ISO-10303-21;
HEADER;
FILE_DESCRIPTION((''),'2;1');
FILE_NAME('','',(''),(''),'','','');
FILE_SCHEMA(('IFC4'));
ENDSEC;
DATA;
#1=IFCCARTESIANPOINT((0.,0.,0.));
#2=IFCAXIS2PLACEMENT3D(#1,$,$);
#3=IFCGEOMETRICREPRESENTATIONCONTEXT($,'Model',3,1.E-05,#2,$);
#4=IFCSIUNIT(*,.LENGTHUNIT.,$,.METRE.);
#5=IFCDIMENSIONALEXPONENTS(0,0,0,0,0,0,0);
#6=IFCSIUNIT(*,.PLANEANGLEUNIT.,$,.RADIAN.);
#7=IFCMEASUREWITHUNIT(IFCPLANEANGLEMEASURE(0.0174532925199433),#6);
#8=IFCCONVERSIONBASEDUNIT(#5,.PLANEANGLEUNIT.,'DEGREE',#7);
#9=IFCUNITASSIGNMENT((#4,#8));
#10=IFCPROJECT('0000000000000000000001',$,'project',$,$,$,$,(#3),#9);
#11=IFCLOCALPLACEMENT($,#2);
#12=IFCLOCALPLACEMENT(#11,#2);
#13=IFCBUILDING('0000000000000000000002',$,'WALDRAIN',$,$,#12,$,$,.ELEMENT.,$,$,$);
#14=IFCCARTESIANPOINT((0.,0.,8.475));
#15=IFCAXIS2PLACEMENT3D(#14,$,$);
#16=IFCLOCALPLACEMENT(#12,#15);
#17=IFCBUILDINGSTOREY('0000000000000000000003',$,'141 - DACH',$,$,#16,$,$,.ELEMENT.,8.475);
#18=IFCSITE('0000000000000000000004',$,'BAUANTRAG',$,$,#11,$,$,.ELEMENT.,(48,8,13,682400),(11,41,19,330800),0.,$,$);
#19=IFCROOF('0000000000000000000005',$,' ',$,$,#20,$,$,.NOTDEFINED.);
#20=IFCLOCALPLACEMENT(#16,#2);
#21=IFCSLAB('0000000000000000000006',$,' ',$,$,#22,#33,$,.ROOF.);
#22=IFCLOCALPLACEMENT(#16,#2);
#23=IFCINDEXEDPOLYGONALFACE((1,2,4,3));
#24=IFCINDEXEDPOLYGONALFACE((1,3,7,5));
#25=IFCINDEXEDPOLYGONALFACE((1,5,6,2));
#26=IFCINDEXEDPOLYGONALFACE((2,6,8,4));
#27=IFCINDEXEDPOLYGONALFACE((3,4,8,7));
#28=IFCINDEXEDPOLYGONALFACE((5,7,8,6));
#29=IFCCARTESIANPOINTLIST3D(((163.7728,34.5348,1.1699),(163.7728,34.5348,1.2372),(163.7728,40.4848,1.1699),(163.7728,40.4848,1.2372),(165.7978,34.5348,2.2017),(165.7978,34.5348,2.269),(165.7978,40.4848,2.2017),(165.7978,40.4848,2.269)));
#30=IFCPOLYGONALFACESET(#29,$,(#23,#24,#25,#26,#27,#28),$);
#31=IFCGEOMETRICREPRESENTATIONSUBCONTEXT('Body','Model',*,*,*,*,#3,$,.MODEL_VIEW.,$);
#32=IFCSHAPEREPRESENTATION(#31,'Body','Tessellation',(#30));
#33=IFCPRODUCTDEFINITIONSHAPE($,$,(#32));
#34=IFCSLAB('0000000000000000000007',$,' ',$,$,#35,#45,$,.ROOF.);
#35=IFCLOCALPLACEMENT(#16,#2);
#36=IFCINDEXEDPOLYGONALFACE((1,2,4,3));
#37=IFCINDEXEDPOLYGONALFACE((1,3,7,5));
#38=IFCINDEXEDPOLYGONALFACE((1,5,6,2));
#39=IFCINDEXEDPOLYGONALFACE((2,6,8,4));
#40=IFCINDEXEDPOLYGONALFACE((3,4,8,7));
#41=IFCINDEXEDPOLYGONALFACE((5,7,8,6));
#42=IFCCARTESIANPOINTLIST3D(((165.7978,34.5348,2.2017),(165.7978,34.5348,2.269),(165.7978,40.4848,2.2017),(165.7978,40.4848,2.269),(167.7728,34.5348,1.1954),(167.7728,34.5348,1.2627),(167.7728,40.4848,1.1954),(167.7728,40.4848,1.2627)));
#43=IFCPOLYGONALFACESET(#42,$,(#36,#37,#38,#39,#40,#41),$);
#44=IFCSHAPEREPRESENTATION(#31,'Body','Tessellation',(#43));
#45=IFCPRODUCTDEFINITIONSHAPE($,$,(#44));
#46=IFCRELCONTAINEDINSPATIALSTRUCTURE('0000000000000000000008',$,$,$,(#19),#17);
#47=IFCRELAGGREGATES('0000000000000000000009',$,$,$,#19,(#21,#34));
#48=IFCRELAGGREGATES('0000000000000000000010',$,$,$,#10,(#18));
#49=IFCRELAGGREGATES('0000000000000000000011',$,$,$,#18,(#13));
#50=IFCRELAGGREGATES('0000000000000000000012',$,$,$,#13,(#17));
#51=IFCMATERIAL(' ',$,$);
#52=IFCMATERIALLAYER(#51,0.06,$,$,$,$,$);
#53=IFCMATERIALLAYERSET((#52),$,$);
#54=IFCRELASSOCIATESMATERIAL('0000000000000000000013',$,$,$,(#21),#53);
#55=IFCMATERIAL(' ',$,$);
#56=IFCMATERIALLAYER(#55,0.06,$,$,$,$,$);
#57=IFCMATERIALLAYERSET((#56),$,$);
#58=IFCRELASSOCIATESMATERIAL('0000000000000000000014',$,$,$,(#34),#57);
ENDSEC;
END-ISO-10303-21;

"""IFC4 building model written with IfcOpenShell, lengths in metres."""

from ifc_helpers import new_model, entity, si_unit, converted_unit, frame, frame_2d, origin, origin_2d_with_axis, place, context, subcontext, project, spatial, rectangle, extrude, material, layer, layer_set, layer_usage, element, aggregate, save


model = new_model("IFC4")

# Units and contexts
model_context = context("Model", 3, precision=1e-05, world=origin())
body_context = subcontext(model_context, "Body", "Model", "MODEL_VIEW")
ifc_project = project(units=[si_unit("LENGTHUNIT", "METRE"), converted_unit("PLANEANGLEUNIT", "DEGREE", entity("IfcPlaneAngleMeasure", 0.0174532925199433), si_unit("PLANEANGLEUNIT", "RADIAN"), dimensions=[0, 0, 0, 0, 0, 0, 0])], contexts=[model_context])

# Site, building, storey
site_placement = place(None, origin())
site = spatial("IfcSite", under=ifc_project, at=site_placement, Name="BAUANTRAG", CompositionType="ELEMENT", RefLatitude=(48, 8, 13, 682400), RefLongitude=(11, 41, 19, 330800), RefElevation=0.0)
building_placement = place(site_placement, origin())
building = spatial("IfcBuilding", under=site, at=building_placement, Name="WALDRAIN", CompositionType="ELEMENT")
storey_placement = place(building_placement, frame((0.0, 0.0, 8.475)))
storey = spatial("IfcBuildingStorey", under=building, at=storey_placement, Name="141 - DACH", CompositionType="ELEMENT", Elevation=8.475)

# Roof, slabs
roof_placement = place(storey_placement, frame((0.0, 0.0, -8.475)))
roof = element("IfcRoof", 1, at=roof_placement, inside=storey, Name=" ", PredefinedType="NOTDEFINED")
ifc_material_1 = material(Name=" ")
ifc_layer_1 = layer(ifc_material_1, 0.06)
ifc_layer_set_1 = layer_set([ifc_layer_1])
ifc_layer_usage_1 = layer_usage(ifc_layer_set_1, "AXIS3", "POSITIVE", 0.0)
slab_1_placement = place(roof_placement, frame((163.7728, 34.5348, 9.6449)))
slab_1 = element("IfcSlab", 2, at=slab_1_placement, material=ifc_layer_usage_1, Name=" ", PredefinedType="ROOF", context=body_context, shape_type="SweptSolid", body=[
    extrude(rectangle(XDim=5.95, YDim=2.2727, at=origin_2d_with_axis()), frame((1.0125, 2.975, 0.5159), z_axis=(-0.45399, 0.0, 0.891007), x_axis=(0.0, 1.0, 0.0)), (0.0, -0.45399, 0.891007), 0.0673),
])
ifc_material_2 = material(Name=" ")
ifc_layer_2 = layer(ifc_material_2, 0.06)
ifc_layer_set_2 = layer_set([ifc_layer_2])
ifc_layer_usage_2 = layer_usage(ifc_layer_set_2, "AXIS3", "POSITIVE", 0.0)
slab_2_placement = place(roof_placement, frame((165.7978, 34.5348, 9.6704)))
slab_2 = element("IfcSlab", 3, at=slab_2_placement, material=ifc_layer_usage_2, Name=" ", PredefinedType="ROOF", context=body_context, shape_type="SweptSolid", body=[
    extrude(rectangle(XDim=2.2166, YDim=5.95, at=frame_2d((0.0, 0.0), x_axis=(0.0, -1.0))), frame((0.9875, 2.975, 0.5032), z_axis=(0.45399, 0.0, 0.891007), x_axis=(0.0, -1.0, 0.0)), (0.0, -0.45399, 0.891007), 0.0673),
])
aggregate(roof, [slab_1, slab_2])

save(model, "model.ifc")
